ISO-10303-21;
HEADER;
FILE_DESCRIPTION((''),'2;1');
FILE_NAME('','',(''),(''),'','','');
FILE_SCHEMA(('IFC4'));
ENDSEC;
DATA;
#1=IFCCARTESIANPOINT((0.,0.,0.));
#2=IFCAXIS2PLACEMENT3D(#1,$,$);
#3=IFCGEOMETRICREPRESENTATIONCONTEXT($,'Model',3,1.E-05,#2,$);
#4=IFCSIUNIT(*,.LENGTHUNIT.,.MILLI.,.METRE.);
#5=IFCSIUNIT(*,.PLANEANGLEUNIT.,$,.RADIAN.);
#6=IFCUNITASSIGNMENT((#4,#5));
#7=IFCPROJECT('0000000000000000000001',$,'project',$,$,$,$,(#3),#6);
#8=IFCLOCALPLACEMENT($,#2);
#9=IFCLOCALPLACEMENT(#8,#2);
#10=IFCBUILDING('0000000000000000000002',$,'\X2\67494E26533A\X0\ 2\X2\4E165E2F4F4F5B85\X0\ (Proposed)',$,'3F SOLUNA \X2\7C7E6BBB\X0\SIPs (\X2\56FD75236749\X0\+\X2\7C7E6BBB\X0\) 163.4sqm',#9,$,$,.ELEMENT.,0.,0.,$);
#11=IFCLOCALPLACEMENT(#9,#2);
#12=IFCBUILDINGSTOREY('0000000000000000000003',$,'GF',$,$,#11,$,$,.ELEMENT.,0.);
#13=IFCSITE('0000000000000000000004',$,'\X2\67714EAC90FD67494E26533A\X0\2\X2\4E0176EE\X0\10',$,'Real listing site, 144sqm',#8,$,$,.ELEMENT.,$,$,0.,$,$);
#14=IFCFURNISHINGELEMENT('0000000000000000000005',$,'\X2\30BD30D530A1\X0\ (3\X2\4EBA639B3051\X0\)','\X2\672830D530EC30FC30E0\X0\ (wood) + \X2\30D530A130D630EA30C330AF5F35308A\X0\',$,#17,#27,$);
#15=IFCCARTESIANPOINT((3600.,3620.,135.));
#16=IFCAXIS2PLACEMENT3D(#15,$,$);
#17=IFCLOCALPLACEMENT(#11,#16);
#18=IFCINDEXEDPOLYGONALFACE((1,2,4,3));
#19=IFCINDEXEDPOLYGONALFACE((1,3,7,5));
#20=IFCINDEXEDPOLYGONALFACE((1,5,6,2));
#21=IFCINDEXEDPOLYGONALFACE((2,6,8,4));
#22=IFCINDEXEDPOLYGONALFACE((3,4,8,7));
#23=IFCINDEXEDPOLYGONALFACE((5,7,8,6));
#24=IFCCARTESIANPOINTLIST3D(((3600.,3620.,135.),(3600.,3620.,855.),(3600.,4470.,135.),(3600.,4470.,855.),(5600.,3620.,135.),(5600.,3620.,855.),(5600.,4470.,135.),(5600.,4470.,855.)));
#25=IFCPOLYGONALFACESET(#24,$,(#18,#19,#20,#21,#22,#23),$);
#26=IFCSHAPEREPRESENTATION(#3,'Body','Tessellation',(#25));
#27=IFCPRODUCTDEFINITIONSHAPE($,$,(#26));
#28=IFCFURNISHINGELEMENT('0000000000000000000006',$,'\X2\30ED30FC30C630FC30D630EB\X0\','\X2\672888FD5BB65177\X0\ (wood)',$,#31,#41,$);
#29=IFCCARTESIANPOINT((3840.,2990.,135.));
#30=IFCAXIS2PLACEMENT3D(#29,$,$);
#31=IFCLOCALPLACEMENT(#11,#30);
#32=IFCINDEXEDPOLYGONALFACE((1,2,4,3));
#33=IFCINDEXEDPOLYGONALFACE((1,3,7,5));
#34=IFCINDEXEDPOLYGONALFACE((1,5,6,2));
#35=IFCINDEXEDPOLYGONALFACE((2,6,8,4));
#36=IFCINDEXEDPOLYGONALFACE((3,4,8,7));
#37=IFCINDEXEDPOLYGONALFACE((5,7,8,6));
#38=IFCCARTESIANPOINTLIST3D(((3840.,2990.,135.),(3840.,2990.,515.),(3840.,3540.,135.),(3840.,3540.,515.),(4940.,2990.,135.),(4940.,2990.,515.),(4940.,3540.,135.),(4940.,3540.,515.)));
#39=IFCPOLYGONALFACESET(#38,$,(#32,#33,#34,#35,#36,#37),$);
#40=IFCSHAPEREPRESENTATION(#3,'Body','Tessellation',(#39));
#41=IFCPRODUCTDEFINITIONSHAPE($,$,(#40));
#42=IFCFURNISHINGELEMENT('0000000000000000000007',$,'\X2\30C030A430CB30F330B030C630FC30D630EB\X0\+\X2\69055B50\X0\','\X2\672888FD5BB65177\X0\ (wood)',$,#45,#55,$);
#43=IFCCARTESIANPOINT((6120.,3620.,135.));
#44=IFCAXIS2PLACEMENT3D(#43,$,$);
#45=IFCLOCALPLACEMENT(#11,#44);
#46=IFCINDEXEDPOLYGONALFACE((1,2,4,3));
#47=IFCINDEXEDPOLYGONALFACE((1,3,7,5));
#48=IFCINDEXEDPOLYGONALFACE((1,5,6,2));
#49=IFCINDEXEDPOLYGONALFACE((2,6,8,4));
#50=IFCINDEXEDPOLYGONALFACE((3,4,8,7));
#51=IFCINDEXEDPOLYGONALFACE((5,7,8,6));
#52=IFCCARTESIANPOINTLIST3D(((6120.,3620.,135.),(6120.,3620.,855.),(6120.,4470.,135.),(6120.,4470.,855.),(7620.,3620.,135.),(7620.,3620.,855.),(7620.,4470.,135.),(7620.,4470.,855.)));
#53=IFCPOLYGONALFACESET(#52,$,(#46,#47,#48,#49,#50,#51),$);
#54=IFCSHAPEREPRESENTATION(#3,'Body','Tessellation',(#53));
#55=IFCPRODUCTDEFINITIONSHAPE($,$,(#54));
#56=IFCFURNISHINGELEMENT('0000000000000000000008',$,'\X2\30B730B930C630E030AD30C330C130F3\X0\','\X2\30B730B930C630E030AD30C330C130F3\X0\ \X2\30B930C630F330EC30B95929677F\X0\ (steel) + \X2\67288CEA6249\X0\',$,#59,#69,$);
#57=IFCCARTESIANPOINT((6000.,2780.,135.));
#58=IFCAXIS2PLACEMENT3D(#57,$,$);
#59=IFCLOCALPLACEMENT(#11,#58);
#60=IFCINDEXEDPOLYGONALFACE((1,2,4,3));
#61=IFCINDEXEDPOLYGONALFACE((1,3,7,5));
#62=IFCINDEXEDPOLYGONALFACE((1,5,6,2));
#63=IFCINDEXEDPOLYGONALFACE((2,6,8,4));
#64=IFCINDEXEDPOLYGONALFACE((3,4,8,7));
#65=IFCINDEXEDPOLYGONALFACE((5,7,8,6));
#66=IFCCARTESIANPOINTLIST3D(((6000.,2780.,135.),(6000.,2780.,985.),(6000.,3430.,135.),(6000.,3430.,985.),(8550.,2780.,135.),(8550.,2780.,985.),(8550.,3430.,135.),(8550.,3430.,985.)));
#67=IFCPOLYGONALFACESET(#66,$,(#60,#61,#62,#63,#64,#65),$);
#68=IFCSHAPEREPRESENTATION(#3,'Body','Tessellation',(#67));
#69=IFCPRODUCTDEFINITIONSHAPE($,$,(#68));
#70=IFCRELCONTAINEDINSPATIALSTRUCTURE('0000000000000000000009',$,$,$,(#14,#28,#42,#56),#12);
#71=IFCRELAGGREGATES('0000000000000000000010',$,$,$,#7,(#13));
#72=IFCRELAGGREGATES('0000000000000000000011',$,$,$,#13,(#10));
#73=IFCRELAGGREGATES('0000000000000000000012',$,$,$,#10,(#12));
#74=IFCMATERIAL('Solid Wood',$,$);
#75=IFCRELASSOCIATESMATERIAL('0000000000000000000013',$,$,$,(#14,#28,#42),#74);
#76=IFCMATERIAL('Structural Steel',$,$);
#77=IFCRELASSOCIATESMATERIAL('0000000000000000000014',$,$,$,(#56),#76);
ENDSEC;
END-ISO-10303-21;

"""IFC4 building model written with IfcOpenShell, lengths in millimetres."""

from ifc_helpers import new_model, si_unit, frame, frame_2d, origin, place, context, project, spatial, rectangle, extrude, material, element, save


model = new_model("IFC4")

# Units and contexts
model_context = context("Model", 3, precision=1e-05, world=origin())
ifc_project = project(units=[si_unit("LENGTHUNIT", "METRE", prefix="MILLI"), si_unit("PLANEANGLEUNIT", "RADIAN")], contexts=[model_context])

# Site, building, storey
site_placement = place(None, origin())
site = spatial("IfcSite", under=ifc_project, at=site_placement, Name="東京都杉並区2丁目10", ObjectType="Real listing site, 144sqm", CompositionType="ELEMENT", RefElevation=0.0)
building_placement = place(site_placement, origin())
building = spatial("IfcBuilding", under=site, at=building_placement, Name="杉並区 2世帯住宅 (Proposed)", ObjectType="3F SOLUNA 籾殻SIPs (国産杉+籾殻) 163.4sqm", CompositionType="ELEMENT", ElevationOfRefHeight=0.0, ElevationOfTerrain=0.0)
storey_placement = place(building_placement, origin())
storey = spatial("IfcBuildingStorey", under=building, at=storey_placement, Name="GF", CompositionType="ELEMENT", Elevation=0.0)

# Shared definitions
ifc_material_1 = material(Name="Solid Wood")

# Furnishing elements
furnishing_1_placement = place(storey_placement, frame((3600.0, 3620.0, 135.0)))
element("IfcFurnishingElement", 1, at=furnishing_1_placement, inside=storey, material=ifc_material_1, Name="ソファ (3人掛け)", Description="木フレーム (wood) + ファブリック張り", context=model_context, shape_type="SweptSolid", body=[
    extrude(rectangle(XDim=2000.0, YDim=850.0, at=frame_2d((1000.0, 425.0))), frame((3600.0, 3620.0, 135.0)), (0.0, 0.0, 1.0), 720.0),
])
furnishing_2_placement = place(storey_placement, frame((3840.0, 2990.0, 135.0)))
element("IfcFurnishingElement", 2, at=furnishing_2_placement, inside=storey, material=ifc_material_1, Name="ローテーブル", Description="木製家具 (wood)", context=model_context, shape_type="SweptSolid", body=[
    extrude(rectangle(XDim=1100.0, YDim=550.0, at=frame_2d((550.0, 275.0))), frame((3840.0, 2990.0, 135.0)), (0.0, 0.0, 1.0), 380.0),
])
furnishing_3_placement = place(storey_placement, frame((6120.0, 3620.0, 135.0)))
element("IfcFurnishingElement", 3, at=furnishing_3_placement, inside=storey, material=ifc_material_1, Name="ダイニングテーブル+椅子", Description="木製家具 (wood)", context=model_context, shape_type="SweptSolid", body=[
    extrude(rectangle(XDim=1500.0, YDim=850.0, at=frame_2d((750.0, 425.0))), frame((6120.0, 3620.0, 135.0)), (0.0, 0.0, 1.0), 720.0),
])
ifc_material_2 = material(Name="Structural Steel")
furnishing_4_placement = place(storey_placement, frame((6000.0, 2780.0, 135.0)))
element("IfcFurnishingElement", 4, at=furnishing_4_placement, inside=storey, material=ifc_material_2, Name="システムキッチン", Description="システムキッチン ステンレス天板 (steel) + 木質扉", context=model_context, shape_type="SweptSolid", body=[
    extrude(rectangle(XDim=2550.0, YDim=650.0, at=frame_2d((1275.0, 325.0))), frame((6000.0, 2780.0, 135.0)), (0.0, 0.0, 1.0), 850.0),
])

save(model, "model.ifc")
